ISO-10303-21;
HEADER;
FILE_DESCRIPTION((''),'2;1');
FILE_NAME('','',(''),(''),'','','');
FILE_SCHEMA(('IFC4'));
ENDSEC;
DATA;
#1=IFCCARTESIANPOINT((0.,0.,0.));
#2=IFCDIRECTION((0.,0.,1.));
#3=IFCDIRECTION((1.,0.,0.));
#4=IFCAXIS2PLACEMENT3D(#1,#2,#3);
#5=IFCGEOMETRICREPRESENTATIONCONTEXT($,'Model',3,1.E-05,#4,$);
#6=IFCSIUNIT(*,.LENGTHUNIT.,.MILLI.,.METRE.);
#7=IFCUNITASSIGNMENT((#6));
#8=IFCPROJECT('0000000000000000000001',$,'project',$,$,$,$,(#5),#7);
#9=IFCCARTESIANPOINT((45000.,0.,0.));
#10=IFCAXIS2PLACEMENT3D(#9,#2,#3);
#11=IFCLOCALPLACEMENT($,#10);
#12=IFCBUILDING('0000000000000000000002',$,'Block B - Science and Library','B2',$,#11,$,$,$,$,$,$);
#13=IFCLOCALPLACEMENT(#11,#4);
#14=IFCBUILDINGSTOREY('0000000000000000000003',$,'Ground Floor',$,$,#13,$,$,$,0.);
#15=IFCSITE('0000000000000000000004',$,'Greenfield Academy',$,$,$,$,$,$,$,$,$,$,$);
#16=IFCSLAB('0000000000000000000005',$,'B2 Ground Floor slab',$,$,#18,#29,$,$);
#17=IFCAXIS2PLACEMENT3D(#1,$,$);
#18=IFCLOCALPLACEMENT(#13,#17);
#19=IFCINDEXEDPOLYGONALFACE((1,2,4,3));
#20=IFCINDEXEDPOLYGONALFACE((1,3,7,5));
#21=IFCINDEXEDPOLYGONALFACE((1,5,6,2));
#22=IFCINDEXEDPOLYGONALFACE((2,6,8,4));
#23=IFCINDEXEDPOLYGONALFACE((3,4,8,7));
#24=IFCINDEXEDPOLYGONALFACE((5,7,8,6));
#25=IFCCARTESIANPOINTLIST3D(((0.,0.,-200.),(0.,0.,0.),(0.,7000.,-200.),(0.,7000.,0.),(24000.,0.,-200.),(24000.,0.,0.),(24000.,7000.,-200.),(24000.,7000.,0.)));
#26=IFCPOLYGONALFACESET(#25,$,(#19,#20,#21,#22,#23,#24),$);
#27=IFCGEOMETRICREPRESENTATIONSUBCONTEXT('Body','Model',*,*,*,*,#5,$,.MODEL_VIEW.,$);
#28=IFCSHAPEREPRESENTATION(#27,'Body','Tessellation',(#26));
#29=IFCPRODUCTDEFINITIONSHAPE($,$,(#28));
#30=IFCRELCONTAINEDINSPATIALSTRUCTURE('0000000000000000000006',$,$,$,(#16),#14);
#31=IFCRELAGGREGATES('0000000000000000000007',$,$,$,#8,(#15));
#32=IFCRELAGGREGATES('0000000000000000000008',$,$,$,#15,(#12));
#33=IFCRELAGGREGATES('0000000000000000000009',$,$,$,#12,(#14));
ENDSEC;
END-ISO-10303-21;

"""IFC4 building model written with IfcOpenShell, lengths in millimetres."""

from ifc_helpers import new_model, si_unit, frame, origin_with_axes, place, context, subcontext, project, spatial, indexed_curve, outline, extrude, element, save


model = new_model("IFC4")

# Units and contexts
model_context = context("Model", 3, precision=1e-05, world=origin_with_axes())
body_context = subcontext(model_context, "Body", "Model", "MODEL_VIEW")
ifc_project = project(units=[si_unit("LENGTHUNIT", "METRE", prefix="MILLI")], contexts=[model_context])

# Site, building, storey
site = spatial("IfcSite", under=ifc_project, Name="Greenfield Academy")
building_placement = place(None, frame((45000.0, 0.0, 0.0), z_axis=(0.0, 0.0, 1.0), x_axis=(1.0, 0.0, 0.0)))
building = spatial("IfcBuilding", under=site, at=building_placement, Name="Block B - Science and Library", Description="B2")
storey_placement = place(building_placement, origin_with_axes())
storey = spatial("IfcBuildingStorey", under=building, at=storey_placement, Name="Ground Floor", Elevation=0.0)

# Slab
slab_placement = place(storey_placement, frame((0.0, 0.0, -200.0), z_axis=(0.0, 0.0, 1.0), x_axis=(1.0, 0.0, 0.0)))
element("IfcSlab", 1, at=slab_placement, inside=storey, Name="B2 Ground Floor slab", context=body_context, shape_type="SweptSolid", body=[
    extrude(outline(indexed_curve([(0.0, 0.0), (0.0, 7000.0), (24000.0, 7000.0), (24000.0, 0.0), (0.0, 0.0)], self_intersect=False)), origin_with_axes(), (0.0, 0.0, 1.0), 200.0),
])

save(model, "model.ifc")
